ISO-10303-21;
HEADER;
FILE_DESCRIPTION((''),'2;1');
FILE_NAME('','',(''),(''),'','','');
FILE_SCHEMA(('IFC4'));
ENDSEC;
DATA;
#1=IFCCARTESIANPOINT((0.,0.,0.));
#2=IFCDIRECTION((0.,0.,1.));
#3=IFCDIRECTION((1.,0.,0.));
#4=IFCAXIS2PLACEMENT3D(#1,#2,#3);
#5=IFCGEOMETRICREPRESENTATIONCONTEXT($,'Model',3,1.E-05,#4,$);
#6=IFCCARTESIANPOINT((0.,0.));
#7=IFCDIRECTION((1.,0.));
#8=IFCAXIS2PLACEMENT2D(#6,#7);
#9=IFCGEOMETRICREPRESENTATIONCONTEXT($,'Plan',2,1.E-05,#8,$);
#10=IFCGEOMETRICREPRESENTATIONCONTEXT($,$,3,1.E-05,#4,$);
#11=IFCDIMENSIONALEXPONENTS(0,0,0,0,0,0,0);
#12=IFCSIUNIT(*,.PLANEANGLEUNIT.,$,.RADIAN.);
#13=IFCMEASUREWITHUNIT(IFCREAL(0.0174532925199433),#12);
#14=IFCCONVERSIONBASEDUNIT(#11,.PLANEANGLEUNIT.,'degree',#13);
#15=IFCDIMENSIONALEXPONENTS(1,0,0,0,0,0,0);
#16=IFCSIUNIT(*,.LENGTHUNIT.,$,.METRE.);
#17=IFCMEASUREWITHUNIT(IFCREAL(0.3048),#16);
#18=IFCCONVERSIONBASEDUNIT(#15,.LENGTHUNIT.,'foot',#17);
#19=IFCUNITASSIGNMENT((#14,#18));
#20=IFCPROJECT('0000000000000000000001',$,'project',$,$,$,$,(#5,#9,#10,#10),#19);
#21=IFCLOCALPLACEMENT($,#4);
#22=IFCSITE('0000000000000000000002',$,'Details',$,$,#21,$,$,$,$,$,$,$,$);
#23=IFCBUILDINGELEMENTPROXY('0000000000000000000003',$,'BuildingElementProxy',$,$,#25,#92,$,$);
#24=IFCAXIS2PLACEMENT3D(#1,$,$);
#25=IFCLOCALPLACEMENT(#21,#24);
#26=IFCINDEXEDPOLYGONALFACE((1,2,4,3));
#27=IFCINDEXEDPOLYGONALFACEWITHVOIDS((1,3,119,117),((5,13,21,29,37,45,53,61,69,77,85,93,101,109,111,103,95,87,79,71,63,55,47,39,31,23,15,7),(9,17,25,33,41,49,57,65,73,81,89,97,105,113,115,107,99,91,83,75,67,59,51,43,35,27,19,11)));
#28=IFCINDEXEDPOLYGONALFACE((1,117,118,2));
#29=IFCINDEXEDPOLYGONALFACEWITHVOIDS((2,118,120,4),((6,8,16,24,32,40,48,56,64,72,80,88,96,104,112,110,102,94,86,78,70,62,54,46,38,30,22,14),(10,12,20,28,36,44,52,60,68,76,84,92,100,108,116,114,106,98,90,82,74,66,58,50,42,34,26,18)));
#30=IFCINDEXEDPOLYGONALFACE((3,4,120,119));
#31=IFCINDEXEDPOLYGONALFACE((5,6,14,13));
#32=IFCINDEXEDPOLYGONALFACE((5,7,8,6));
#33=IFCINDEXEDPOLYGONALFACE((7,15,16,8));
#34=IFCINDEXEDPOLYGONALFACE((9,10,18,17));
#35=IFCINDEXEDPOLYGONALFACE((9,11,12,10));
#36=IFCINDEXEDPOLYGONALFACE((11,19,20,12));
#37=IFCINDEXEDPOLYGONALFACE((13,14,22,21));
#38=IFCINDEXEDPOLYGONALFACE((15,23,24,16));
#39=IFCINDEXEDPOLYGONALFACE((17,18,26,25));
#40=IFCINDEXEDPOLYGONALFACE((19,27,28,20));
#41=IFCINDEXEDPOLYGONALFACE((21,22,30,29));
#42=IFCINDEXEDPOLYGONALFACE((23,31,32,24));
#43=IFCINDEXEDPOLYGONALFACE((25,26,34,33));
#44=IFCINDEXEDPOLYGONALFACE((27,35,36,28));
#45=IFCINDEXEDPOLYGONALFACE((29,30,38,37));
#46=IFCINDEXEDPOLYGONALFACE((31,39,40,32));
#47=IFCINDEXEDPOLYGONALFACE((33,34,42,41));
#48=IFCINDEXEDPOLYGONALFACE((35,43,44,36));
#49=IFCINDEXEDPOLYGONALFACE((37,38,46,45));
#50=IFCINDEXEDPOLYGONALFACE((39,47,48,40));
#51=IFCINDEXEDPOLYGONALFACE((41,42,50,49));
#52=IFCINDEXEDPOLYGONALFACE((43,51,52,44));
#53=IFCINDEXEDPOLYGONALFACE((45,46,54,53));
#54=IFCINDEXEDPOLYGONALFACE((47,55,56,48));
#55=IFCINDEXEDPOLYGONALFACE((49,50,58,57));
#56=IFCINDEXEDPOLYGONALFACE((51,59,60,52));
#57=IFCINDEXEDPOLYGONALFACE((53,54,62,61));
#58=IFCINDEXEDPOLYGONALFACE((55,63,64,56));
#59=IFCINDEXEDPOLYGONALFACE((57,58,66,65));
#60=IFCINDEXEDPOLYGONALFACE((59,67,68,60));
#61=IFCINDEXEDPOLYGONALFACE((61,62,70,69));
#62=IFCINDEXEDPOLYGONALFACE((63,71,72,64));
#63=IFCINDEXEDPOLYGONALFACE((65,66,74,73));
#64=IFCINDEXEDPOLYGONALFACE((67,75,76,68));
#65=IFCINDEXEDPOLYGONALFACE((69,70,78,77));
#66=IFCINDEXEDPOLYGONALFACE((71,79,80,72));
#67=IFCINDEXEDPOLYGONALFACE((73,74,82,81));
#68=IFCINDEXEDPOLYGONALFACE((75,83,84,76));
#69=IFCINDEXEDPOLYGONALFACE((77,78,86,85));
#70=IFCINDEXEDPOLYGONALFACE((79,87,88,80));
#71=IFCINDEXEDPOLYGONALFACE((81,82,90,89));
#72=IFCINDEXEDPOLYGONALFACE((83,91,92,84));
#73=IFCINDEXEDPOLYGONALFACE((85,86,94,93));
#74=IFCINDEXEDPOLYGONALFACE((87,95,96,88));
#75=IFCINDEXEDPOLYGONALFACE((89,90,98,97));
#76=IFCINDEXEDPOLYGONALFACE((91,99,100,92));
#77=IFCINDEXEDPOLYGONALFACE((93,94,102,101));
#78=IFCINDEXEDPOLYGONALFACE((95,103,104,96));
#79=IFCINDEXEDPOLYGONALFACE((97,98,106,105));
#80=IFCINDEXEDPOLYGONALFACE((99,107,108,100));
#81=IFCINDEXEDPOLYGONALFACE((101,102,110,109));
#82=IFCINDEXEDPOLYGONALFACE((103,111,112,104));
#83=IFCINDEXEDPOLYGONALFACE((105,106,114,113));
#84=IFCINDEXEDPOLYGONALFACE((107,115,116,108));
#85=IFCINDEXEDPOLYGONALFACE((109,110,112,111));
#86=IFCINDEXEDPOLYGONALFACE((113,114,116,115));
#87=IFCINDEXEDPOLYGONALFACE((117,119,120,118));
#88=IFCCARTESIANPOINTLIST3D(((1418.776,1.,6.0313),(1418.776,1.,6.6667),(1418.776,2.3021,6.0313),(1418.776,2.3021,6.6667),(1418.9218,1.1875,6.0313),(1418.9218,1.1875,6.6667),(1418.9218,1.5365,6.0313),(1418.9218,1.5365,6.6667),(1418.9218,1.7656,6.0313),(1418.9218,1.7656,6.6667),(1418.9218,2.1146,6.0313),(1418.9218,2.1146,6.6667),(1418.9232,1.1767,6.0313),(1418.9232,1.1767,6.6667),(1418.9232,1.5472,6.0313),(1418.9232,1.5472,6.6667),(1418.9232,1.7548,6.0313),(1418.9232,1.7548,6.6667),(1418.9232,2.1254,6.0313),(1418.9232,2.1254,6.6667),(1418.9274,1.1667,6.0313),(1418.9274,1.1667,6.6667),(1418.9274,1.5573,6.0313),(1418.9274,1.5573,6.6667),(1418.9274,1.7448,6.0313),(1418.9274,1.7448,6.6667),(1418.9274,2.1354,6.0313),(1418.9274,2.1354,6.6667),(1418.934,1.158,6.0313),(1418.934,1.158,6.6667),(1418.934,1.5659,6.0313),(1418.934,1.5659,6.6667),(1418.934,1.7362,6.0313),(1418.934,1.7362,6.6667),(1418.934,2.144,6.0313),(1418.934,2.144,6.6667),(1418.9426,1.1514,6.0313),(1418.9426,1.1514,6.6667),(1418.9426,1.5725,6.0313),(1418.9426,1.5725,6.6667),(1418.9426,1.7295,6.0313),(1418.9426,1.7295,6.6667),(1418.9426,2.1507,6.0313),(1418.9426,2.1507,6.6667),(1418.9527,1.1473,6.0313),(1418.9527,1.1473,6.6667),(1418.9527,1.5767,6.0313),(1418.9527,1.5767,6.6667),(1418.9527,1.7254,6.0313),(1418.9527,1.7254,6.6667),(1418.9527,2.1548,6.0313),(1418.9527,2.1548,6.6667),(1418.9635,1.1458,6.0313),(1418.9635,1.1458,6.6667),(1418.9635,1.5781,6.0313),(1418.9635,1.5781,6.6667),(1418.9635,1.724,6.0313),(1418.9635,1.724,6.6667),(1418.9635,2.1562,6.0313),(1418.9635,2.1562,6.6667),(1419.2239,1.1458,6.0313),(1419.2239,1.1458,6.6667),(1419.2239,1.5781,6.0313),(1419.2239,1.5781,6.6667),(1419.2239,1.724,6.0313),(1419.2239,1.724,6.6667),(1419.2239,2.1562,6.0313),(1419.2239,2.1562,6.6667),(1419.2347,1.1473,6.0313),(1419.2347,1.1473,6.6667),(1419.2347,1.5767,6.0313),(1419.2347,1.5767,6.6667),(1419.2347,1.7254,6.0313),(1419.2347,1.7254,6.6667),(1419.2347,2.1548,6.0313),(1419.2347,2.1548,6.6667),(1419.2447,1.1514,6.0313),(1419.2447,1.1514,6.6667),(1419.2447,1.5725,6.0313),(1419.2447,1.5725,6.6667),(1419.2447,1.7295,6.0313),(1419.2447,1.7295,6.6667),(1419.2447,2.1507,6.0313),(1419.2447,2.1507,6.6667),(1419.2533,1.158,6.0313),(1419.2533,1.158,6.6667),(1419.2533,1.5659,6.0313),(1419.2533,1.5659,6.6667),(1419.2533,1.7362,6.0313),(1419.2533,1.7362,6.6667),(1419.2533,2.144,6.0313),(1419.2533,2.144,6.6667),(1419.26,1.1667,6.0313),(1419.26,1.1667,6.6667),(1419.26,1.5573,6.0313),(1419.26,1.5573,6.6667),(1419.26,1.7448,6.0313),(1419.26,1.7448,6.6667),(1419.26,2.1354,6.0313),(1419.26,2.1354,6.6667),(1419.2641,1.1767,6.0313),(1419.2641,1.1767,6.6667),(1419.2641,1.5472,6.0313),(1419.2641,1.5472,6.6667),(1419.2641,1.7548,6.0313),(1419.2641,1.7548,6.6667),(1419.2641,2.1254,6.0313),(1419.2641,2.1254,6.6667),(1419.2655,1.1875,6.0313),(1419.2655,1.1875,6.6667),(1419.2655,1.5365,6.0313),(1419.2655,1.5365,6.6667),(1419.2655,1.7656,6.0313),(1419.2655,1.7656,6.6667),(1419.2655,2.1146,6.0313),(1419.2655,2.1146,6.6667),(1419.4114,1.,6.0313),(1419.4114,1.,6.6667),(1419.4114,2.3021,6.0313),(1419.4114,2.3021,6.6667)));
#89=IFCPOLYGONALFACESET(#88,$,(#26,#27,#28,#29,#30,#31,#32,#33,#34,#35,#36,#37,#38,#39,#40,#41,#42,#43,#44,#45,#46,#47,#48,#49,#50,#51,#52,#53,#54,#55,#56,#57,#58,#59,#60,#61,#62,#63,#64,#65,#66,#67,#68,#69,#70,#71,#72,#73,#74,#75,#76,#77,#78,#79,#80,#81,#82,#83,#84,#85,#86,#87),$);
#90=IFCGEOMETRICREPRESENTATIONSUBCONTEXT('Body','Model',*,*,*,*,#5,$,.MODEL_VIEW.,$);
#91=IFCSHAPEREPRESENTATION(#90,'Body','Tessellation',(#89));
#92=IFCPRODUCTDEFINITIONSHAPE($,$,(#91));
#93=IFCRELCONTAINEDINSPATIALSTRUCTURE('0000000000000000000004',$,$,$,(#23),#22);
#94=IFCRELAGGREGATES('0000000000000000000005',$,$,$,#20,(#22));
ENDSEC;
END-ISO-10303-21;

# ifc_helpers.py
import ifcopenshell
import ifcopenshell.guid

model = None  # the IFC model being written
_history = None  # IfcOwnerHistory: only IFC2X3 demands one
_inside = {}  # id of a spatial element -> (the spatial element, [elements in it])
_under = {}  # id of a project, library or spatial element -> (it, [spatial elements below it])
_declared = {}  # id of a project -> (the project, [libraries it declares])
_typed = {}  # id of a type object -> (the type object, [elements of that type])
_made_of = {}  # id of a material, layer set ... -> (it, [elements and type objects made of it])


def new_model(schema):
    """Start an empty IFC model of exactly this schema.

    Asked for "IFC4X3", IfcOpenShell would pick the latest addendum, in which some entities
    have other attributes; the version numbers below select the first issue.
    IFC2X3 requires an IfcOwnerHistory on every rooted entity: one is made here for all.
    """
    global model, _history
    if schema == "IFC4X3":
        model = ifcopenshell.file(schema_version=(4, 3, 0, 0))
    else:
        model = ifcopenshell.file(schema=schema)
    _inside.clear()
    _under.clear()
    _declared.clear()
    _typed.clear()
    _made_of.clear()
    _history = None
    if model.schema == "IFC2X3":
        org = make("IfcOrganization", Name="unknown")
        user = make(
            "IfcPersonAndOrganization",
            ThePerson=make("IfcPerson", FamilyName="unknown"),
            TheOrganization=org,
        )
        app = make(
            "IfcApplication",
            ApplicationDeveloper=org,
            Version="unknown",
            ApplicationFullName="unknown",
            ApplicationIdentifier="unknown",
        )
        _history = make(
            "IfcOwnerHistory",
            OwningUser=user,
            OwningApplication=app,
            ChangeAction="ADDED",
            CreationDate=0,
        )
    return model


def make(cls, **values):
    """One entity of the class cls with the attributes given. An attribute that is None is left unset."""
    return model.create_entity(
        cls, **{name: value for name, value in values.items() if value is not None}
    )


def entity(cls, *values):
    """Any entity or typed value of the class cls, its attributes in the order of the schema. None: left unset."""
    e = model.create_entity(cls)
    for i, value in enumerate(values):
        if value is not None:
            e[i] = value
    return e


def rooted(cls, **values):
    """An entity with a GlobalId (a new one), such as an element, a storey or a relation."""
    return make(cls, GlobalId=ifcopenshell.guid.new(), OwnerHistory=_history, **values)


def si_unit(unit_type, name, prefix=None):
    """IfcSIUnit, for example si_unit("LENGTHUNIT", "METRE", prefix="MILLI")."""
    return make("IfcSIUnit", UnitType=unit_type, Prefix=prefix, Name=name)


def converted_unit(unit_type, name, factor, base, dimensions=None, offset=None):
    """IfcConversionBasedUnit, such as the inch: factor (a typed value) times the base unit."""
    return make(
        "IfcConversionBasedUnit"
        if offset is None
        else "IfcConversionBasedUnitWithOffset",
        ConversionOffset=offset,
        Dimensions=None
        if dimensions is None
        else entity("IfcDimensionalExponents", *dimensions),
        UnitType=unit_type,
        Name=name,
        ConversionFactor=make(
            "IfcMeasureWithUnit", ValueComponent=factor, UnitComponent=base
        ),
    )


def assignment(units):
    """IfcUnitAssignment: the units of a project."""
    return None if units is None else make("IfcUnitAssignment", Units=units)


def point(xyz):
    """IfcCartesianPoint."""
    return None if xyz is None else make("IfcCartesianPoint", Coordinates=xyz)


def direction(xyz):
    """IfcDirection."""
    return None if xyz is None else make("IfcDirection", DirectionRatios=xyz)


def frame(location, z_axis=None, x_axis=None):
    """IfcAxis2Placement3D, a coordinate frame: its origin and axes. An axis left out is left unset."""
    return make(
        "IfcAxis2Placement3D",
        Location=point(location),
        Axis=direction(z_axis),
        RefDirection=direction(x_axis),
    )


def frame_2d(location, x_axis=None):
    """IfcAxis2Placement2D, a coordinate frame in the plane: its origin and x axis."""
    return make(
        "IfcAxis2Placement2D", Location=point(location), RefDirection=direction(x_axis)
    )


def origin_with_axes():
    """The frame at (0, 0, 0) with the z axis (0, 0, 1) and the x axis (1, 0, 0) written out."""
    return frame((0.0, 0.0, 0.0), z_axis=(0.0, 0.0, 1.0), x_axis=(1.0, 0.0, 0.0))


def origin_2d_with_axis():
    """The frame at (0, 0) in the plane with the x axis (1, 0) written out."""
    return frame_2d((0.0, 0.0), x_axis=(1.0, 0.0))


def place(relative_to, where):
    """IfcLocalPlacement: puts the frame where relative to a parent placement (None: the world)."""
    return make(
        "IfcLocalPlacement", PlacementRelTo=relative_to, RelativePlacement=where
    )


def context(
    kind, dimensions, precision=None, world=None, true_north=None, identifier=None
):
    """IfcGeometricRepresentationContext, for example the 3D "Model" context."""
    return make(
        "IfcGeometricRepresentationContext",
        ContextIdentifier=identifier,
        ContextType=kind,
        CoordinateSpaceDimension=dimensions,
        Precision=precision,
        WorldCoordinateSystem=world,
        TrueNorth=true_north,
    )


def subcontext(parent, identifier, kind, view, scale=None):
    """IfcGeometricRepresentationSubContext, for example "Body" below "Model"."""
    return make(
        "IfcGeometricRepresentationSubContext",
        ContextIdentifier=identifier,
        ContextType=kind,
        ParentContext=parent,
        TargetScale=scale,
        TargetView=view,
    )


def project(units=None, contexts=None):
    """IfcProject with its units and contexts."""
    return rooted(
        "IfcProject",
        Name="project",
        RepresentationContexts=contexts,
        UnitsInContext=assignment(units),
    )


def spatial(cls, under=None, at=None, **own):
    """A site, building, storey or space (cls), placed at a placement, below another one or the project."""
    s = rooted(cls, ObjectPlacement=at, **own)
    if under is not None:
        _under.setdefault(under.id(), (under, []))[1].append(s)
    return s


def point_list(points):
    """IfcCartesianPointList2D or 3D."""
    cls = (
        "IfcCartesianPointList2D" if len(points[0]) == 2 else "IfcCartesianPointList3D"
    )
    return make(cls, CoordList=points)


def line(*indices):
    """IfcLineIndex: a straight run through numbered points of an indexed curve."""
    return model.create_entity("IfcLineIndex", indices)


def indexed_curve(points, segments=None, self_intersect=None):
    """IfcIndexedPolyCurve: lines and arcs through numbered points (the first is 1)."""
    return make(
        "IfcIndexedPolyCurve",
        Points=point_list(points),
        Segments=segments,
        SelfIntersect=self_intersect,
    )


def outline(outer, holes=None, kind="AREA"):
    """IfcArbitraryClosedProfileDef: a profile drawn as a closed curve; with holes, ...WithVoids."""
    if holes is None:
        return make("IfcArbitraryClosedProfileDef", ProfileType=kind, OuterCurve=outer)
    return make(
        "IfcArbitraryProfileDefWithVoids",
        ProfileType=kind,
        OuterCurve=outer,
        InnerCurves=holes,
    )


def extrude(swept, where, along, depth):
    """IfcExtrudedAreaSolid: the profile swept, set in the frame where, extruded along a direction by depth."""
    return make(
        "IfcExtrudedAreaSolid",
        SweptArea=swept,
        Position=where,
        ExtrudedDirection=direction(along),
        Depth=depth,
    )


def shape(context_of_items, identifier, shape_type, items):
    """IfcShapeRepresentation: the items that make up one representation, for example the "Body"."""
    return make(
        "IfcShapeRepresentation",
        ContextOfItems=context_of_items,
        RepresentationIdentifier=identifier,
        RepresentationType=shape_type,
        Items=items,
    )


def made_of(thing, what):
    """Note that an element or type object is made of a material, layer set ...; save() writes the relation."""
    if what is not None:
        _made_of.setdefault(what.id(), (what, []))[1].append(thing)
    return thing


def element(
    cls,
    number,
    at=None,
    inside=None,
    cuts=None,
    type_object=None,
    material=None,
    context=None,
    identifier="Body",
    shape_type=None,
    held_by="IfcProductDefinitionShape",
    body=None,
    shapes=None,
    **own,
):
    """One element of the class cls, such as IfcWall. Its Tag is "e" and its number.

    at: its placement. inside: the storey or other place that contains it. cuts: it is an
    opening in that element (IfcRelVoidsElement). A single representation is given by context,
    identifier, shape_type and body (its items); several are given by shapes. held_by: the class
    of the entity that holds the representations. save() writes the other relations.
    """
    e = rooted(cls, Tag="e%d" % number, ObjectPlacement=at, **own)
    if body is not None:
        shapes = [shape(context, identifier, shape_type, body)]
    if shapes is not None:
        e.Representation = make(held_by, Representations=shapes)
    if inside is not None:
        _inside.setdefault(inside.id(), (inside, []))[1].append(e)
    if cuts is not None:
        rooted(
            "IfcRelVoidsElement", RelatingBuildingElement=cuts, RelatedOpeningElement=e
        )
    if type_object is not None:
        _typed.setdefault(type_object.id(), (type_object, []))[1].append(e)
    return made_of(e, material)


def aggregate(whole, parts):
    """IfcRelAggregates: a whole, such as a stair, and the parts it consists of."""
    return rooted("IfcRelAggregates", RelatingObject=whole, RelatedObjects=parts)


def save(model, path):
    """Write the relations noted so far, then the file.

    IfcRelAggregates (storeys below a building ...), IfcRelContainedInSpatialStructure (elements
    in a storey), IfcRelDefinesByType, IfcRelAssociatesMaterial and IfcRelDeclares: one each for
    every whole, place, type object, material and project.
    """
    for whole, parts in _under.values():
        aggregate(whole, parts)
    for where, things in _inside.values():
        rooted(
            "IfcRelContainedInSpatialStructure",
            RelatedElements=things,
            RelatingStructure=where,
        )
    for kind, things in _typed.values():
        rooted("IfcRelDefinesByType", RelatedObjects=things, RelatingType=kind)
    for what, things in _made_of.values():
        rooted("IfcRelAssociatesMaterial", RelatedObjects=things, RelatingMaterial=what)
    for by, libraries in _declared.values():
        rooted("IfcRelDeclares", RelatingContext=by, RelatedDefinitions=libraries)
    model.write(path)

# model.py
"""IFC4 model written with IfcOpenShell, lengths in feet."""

from ifc_helpers import new_model, entity, si_unit, converted_unit, frame, origin_with_axes, origin_2d_with_axis, place, context, subcontext, project, spatial, line, indexed_curve, outline, extrude, element, save


model = new_model("IFC4")

# Units and contexts
model_context = context("Model", 3, precision=1e-05, world=origin_with_axes())
plan_context = context("Plan", 2, precision=1e-05, world=origin_2d_with_axis())
context_of_model = context(None, 3, precision=1e-05, world=origin_with_axes())
body_context = subcontext(model_context, "Body", "Model", "MODEL_VIEW")
ifc_project = project(units=[converted_unit("PLANEANGLEUNIT", "degree", entity("IfcReal", 0.0174532925199433), si_unit("PLANEANGLEUNIT", "RADIAN"), dimensions=[0, 0, 0, 0, 0, 0, 0]), converted_unit("LENGTHUNIT", "foot", entity("IfcReal", 0.3048), si_unit("LENGTHUNIT", "METRE"), dimensions=[1, 0, 0, 0, 0, 0, 0])], contexts=[model_context, plan_context, context_of_model, context_of_model])

# Site
site_placement = place(None, origin_with_axes())
site = spatial("IfcSite", under=ifc_project, at=site_placement, Name="Details")

# Building element proxy
proxy_1_placement = place(site_placement, frame((1419.0936, 2.3021, 6.0313), z_axis=(0.0, 0.0, 1.0), x_axis=(0.0, 1.0, 0.0)))
element("IfcBuildingElementProxy", 1, at=proxy_1_placement, inside=site, Name="BuildingElementProxy", context=body_context, shape_type="SweptSolid", body=[
    extrude(outline(indexed_curve([(-0.3177, -0.651), (0.3177, -0.651), (0.3177, 0.651), (-0.3177, 0.651), (0.1719, -0.1146), (0.1719, -0.4635), (0.1705, -0.4743), (0.1663, -0.4844), (0.1597, -0.493), (0.151, -0.4996), (0.141, -0.5038), (0.1302, -0.5052), (-0.1302, -0.5052), (-0.141, -0.5038), (-0.151, -0.4996), (-0.1597, -0.493), (-0.1663, -0.4844), (-0.1705, -0.4743), (-0.1719, -0.4635), (-0.1719, -0.1146), (-0.1705, -0.1038), (-0.1663, -0.0938), (-0.1597, -0.0851), (-0.151, -0.0785), (-0.141, -0.0743), (-0.1302, -0.0729), (0.1302, -0.0729), (0.141, -0.0743), (0.151, -0.0785), (0.1597, -0.0851), (0.1663, -0.0938), (0.1705, -0.1038), (0.151, 0.0785), (0.141, 0.0743), (0.1302, 0.0729), (-0.1302, 0.0729), (-0.141, 0.0743), (-0.151, 0.0785), (-0.1597, 0.0851), (-0.1663, 0.0937), (-0.1705, 0.1038), (-0.1719, 0.1146), (-0.1719, 0.4635), (-0.1705, 0.4743), (-0.1663, 0.4844), (-0.1597, 0.493), (-0.151, 0.4996), (-0.141, 0.5038), (-0.1302, 0.5052), (0.1302, 0.5052), (0.141, 0.5038), (0.151, 0.4996), (0.1597, 0.493), (0.1663, 0.4844), (0.1705, 0.4743), (0.1719, 0.4635), (0.1719, 0.1146), (0.1705, 0.1038), (0.1663, 0.0937), (0.1597, 0.0851)], segments=[line(4, 3), line(3, 2), line(2, 1), line(1, 4)], self_intersect=False), holes=[indexed_curve([(-0.3177, -0.651), (0.3177, -0.651), (0.3177, 0.651), (-0.3177, 0.651), (0.1719, -0.1146), (0.1719, -0.4635), (0.1705, -0.4743), (0.1663, -0.4844), (0.1597, -0.493), (0.151, -0.4996), (0.141, -0.5038), (0.1302, -0.5052), (-0.1302, -0.5052), (-0.141, -0.5038), (-0.151, -0.4996), (-0.1597, -0.493), (-0.1663, -0.4844), (-0.1705, -0.4743), (-0.1719, -0.4635), (-0.1719, -0.1146), (-0.1705, -0.1038), (-0.1663, -0.0938), (-0.1597, -0.0851), (-0.151, -0.0785), (-0.141, -0.0743), (-0.1302, -0.0729), (0.1302, -0.0729), (0.141, -0.0743), (0.151, -0.0785), (0.1597, -0.0851), (0.1663, -0.0938), (0.1705, -0.1038), (0.151, 0.0785), (0.141, 0.0743), (0.1302, 0.0729), (-0.1302, 0.0729), (-0.141, 0.0743), (-0.151, 0.0785), (-0.1597, 0.0851), (-0.1663, 0.0937), (-0.1705, 0.1038), (-0.1719, 0.1146), (-0.1719, 0.4635), (-0.1705, 0.4743), (-0.1663, 0.4844), (-0.1597, 0.493), (-0.151, 0.4996), (-0.141, 0.5038), (-0.1302, 0.5052), (0.1302, 0.5052), (0.141, 0.5038), (0.151, 0.4996), (0.1597, 0.493), (0.1663, 0.4844), (0.1705, 0.4743), (0.1719, 0.4635), (0.1719, 0.1146), (0.1705, 0.1038), (0.1663, 0.0937), (0.1597, 0.0851)], segments=[line(20, 19), line(19, 18), line(18, 17), line(17, 16), line(16, 15), line(15, 14), line(14, 13), line(13, 12), line(12, 11), line(11, 10), line(10, 9), line(9, 8), line(8, 7), line(7, 6), line(6, 5), line(5, 32), line(32, 31), line(31, 30), line(30, 29), line(29, 28), line(28, 27), line(27, 26), line(26, 25), line(25, 24), line(24, 23), line(23, 22), line(22, 21), line(21, 20)], self_intersect=False), indexed_curve([(-0.3177, -0.651), (0.3177, -0.651), (0.3177, 0.651), (-0.3177, 0.651), (0.1719, -0.1146), (0.1719, -0.4635), (0.1705, -0.4743), (0.1663, -0.4844), (0.1597, -0.493), (0.151, -0.4996), (0.141, -0.5038), (0.1302, -0.5052), (-0.1302, -0.5052), (-0.141, -0.5038), (-0.151, -0.4996), (-0.1597, -0.493), (-0.1663, -0.4844), (-0.1705, -0.4743), (-0.1719, -0.4635), (-0.1719, -0.1146), (-0.1705, -0.1038), (-0.1663, -0.0938), (-0.1597, -0.0851), (-0.151, -0.0785), (-0.141, -0.0743), (-0.1302, -0.0729), (0.1302, -0.0729), (0.141, -0.0743), (0.151, -0.0785), (0.1597, -0.0851), (0.1663, -0.0938), (0.1705, -0.1038), (0.151, 0.0785), (0.141, 0.0743), (0.1302, 0.0729), (-0.1302, 0.0729), (-0.141, 0.0743), (-0.151, 0.0785), (-0.1597, 0.0851), (-0.1663, 0.0937), (-0.1705, 0.1038), (-0.1719, 0.1146), (-0.1719, 0.4635), (-0.1705, 0.4743), (-0.1663, 0.4844), (-0.1597, 0.493), (-0.151, 0.4996), (-0.141, 0.5038), (-0.1302, 0.5052), (0.1302, 0.5052), (0.141, 0.5038), (0.151, 0.4996), (0.1597, 0.493), (0.1663, 0.4844), (0.1705, 0.4743), (0.1719, 0.4635), (0.1719, 0.1146), (0.1705, 0.1038), (0.1663, 0.0937), (0.1597, 0.0851)], segments=[line(44, 43), line(43, 42), line(42, 41), line(41, 40), line(40, 39), line(39, 38), line(38, 37), line(37, 36), line(36, 35), line(35, 34), line(34, 33), line(33, 60), line(60, 59), line(59, 58), line(58, 57), line(57, 56), line(56, 55), line(55, 54), line(54, 53), line(53, 52), line(52, 51), line(51, 50), line(50, 49), line(49, 48), line(48, 47), line(47, 46), line(46, 45), line(45, 44)], self_intersect=False)]), frame((-0.651, 0.0, 0.0), z_axis=(0.0, 0.0, 1.0), x_axis=(0.0, -1.0, 0.0)), (0.0, 0.0, 1.0), 0.6354),
])

save(model, "model.ifc")
